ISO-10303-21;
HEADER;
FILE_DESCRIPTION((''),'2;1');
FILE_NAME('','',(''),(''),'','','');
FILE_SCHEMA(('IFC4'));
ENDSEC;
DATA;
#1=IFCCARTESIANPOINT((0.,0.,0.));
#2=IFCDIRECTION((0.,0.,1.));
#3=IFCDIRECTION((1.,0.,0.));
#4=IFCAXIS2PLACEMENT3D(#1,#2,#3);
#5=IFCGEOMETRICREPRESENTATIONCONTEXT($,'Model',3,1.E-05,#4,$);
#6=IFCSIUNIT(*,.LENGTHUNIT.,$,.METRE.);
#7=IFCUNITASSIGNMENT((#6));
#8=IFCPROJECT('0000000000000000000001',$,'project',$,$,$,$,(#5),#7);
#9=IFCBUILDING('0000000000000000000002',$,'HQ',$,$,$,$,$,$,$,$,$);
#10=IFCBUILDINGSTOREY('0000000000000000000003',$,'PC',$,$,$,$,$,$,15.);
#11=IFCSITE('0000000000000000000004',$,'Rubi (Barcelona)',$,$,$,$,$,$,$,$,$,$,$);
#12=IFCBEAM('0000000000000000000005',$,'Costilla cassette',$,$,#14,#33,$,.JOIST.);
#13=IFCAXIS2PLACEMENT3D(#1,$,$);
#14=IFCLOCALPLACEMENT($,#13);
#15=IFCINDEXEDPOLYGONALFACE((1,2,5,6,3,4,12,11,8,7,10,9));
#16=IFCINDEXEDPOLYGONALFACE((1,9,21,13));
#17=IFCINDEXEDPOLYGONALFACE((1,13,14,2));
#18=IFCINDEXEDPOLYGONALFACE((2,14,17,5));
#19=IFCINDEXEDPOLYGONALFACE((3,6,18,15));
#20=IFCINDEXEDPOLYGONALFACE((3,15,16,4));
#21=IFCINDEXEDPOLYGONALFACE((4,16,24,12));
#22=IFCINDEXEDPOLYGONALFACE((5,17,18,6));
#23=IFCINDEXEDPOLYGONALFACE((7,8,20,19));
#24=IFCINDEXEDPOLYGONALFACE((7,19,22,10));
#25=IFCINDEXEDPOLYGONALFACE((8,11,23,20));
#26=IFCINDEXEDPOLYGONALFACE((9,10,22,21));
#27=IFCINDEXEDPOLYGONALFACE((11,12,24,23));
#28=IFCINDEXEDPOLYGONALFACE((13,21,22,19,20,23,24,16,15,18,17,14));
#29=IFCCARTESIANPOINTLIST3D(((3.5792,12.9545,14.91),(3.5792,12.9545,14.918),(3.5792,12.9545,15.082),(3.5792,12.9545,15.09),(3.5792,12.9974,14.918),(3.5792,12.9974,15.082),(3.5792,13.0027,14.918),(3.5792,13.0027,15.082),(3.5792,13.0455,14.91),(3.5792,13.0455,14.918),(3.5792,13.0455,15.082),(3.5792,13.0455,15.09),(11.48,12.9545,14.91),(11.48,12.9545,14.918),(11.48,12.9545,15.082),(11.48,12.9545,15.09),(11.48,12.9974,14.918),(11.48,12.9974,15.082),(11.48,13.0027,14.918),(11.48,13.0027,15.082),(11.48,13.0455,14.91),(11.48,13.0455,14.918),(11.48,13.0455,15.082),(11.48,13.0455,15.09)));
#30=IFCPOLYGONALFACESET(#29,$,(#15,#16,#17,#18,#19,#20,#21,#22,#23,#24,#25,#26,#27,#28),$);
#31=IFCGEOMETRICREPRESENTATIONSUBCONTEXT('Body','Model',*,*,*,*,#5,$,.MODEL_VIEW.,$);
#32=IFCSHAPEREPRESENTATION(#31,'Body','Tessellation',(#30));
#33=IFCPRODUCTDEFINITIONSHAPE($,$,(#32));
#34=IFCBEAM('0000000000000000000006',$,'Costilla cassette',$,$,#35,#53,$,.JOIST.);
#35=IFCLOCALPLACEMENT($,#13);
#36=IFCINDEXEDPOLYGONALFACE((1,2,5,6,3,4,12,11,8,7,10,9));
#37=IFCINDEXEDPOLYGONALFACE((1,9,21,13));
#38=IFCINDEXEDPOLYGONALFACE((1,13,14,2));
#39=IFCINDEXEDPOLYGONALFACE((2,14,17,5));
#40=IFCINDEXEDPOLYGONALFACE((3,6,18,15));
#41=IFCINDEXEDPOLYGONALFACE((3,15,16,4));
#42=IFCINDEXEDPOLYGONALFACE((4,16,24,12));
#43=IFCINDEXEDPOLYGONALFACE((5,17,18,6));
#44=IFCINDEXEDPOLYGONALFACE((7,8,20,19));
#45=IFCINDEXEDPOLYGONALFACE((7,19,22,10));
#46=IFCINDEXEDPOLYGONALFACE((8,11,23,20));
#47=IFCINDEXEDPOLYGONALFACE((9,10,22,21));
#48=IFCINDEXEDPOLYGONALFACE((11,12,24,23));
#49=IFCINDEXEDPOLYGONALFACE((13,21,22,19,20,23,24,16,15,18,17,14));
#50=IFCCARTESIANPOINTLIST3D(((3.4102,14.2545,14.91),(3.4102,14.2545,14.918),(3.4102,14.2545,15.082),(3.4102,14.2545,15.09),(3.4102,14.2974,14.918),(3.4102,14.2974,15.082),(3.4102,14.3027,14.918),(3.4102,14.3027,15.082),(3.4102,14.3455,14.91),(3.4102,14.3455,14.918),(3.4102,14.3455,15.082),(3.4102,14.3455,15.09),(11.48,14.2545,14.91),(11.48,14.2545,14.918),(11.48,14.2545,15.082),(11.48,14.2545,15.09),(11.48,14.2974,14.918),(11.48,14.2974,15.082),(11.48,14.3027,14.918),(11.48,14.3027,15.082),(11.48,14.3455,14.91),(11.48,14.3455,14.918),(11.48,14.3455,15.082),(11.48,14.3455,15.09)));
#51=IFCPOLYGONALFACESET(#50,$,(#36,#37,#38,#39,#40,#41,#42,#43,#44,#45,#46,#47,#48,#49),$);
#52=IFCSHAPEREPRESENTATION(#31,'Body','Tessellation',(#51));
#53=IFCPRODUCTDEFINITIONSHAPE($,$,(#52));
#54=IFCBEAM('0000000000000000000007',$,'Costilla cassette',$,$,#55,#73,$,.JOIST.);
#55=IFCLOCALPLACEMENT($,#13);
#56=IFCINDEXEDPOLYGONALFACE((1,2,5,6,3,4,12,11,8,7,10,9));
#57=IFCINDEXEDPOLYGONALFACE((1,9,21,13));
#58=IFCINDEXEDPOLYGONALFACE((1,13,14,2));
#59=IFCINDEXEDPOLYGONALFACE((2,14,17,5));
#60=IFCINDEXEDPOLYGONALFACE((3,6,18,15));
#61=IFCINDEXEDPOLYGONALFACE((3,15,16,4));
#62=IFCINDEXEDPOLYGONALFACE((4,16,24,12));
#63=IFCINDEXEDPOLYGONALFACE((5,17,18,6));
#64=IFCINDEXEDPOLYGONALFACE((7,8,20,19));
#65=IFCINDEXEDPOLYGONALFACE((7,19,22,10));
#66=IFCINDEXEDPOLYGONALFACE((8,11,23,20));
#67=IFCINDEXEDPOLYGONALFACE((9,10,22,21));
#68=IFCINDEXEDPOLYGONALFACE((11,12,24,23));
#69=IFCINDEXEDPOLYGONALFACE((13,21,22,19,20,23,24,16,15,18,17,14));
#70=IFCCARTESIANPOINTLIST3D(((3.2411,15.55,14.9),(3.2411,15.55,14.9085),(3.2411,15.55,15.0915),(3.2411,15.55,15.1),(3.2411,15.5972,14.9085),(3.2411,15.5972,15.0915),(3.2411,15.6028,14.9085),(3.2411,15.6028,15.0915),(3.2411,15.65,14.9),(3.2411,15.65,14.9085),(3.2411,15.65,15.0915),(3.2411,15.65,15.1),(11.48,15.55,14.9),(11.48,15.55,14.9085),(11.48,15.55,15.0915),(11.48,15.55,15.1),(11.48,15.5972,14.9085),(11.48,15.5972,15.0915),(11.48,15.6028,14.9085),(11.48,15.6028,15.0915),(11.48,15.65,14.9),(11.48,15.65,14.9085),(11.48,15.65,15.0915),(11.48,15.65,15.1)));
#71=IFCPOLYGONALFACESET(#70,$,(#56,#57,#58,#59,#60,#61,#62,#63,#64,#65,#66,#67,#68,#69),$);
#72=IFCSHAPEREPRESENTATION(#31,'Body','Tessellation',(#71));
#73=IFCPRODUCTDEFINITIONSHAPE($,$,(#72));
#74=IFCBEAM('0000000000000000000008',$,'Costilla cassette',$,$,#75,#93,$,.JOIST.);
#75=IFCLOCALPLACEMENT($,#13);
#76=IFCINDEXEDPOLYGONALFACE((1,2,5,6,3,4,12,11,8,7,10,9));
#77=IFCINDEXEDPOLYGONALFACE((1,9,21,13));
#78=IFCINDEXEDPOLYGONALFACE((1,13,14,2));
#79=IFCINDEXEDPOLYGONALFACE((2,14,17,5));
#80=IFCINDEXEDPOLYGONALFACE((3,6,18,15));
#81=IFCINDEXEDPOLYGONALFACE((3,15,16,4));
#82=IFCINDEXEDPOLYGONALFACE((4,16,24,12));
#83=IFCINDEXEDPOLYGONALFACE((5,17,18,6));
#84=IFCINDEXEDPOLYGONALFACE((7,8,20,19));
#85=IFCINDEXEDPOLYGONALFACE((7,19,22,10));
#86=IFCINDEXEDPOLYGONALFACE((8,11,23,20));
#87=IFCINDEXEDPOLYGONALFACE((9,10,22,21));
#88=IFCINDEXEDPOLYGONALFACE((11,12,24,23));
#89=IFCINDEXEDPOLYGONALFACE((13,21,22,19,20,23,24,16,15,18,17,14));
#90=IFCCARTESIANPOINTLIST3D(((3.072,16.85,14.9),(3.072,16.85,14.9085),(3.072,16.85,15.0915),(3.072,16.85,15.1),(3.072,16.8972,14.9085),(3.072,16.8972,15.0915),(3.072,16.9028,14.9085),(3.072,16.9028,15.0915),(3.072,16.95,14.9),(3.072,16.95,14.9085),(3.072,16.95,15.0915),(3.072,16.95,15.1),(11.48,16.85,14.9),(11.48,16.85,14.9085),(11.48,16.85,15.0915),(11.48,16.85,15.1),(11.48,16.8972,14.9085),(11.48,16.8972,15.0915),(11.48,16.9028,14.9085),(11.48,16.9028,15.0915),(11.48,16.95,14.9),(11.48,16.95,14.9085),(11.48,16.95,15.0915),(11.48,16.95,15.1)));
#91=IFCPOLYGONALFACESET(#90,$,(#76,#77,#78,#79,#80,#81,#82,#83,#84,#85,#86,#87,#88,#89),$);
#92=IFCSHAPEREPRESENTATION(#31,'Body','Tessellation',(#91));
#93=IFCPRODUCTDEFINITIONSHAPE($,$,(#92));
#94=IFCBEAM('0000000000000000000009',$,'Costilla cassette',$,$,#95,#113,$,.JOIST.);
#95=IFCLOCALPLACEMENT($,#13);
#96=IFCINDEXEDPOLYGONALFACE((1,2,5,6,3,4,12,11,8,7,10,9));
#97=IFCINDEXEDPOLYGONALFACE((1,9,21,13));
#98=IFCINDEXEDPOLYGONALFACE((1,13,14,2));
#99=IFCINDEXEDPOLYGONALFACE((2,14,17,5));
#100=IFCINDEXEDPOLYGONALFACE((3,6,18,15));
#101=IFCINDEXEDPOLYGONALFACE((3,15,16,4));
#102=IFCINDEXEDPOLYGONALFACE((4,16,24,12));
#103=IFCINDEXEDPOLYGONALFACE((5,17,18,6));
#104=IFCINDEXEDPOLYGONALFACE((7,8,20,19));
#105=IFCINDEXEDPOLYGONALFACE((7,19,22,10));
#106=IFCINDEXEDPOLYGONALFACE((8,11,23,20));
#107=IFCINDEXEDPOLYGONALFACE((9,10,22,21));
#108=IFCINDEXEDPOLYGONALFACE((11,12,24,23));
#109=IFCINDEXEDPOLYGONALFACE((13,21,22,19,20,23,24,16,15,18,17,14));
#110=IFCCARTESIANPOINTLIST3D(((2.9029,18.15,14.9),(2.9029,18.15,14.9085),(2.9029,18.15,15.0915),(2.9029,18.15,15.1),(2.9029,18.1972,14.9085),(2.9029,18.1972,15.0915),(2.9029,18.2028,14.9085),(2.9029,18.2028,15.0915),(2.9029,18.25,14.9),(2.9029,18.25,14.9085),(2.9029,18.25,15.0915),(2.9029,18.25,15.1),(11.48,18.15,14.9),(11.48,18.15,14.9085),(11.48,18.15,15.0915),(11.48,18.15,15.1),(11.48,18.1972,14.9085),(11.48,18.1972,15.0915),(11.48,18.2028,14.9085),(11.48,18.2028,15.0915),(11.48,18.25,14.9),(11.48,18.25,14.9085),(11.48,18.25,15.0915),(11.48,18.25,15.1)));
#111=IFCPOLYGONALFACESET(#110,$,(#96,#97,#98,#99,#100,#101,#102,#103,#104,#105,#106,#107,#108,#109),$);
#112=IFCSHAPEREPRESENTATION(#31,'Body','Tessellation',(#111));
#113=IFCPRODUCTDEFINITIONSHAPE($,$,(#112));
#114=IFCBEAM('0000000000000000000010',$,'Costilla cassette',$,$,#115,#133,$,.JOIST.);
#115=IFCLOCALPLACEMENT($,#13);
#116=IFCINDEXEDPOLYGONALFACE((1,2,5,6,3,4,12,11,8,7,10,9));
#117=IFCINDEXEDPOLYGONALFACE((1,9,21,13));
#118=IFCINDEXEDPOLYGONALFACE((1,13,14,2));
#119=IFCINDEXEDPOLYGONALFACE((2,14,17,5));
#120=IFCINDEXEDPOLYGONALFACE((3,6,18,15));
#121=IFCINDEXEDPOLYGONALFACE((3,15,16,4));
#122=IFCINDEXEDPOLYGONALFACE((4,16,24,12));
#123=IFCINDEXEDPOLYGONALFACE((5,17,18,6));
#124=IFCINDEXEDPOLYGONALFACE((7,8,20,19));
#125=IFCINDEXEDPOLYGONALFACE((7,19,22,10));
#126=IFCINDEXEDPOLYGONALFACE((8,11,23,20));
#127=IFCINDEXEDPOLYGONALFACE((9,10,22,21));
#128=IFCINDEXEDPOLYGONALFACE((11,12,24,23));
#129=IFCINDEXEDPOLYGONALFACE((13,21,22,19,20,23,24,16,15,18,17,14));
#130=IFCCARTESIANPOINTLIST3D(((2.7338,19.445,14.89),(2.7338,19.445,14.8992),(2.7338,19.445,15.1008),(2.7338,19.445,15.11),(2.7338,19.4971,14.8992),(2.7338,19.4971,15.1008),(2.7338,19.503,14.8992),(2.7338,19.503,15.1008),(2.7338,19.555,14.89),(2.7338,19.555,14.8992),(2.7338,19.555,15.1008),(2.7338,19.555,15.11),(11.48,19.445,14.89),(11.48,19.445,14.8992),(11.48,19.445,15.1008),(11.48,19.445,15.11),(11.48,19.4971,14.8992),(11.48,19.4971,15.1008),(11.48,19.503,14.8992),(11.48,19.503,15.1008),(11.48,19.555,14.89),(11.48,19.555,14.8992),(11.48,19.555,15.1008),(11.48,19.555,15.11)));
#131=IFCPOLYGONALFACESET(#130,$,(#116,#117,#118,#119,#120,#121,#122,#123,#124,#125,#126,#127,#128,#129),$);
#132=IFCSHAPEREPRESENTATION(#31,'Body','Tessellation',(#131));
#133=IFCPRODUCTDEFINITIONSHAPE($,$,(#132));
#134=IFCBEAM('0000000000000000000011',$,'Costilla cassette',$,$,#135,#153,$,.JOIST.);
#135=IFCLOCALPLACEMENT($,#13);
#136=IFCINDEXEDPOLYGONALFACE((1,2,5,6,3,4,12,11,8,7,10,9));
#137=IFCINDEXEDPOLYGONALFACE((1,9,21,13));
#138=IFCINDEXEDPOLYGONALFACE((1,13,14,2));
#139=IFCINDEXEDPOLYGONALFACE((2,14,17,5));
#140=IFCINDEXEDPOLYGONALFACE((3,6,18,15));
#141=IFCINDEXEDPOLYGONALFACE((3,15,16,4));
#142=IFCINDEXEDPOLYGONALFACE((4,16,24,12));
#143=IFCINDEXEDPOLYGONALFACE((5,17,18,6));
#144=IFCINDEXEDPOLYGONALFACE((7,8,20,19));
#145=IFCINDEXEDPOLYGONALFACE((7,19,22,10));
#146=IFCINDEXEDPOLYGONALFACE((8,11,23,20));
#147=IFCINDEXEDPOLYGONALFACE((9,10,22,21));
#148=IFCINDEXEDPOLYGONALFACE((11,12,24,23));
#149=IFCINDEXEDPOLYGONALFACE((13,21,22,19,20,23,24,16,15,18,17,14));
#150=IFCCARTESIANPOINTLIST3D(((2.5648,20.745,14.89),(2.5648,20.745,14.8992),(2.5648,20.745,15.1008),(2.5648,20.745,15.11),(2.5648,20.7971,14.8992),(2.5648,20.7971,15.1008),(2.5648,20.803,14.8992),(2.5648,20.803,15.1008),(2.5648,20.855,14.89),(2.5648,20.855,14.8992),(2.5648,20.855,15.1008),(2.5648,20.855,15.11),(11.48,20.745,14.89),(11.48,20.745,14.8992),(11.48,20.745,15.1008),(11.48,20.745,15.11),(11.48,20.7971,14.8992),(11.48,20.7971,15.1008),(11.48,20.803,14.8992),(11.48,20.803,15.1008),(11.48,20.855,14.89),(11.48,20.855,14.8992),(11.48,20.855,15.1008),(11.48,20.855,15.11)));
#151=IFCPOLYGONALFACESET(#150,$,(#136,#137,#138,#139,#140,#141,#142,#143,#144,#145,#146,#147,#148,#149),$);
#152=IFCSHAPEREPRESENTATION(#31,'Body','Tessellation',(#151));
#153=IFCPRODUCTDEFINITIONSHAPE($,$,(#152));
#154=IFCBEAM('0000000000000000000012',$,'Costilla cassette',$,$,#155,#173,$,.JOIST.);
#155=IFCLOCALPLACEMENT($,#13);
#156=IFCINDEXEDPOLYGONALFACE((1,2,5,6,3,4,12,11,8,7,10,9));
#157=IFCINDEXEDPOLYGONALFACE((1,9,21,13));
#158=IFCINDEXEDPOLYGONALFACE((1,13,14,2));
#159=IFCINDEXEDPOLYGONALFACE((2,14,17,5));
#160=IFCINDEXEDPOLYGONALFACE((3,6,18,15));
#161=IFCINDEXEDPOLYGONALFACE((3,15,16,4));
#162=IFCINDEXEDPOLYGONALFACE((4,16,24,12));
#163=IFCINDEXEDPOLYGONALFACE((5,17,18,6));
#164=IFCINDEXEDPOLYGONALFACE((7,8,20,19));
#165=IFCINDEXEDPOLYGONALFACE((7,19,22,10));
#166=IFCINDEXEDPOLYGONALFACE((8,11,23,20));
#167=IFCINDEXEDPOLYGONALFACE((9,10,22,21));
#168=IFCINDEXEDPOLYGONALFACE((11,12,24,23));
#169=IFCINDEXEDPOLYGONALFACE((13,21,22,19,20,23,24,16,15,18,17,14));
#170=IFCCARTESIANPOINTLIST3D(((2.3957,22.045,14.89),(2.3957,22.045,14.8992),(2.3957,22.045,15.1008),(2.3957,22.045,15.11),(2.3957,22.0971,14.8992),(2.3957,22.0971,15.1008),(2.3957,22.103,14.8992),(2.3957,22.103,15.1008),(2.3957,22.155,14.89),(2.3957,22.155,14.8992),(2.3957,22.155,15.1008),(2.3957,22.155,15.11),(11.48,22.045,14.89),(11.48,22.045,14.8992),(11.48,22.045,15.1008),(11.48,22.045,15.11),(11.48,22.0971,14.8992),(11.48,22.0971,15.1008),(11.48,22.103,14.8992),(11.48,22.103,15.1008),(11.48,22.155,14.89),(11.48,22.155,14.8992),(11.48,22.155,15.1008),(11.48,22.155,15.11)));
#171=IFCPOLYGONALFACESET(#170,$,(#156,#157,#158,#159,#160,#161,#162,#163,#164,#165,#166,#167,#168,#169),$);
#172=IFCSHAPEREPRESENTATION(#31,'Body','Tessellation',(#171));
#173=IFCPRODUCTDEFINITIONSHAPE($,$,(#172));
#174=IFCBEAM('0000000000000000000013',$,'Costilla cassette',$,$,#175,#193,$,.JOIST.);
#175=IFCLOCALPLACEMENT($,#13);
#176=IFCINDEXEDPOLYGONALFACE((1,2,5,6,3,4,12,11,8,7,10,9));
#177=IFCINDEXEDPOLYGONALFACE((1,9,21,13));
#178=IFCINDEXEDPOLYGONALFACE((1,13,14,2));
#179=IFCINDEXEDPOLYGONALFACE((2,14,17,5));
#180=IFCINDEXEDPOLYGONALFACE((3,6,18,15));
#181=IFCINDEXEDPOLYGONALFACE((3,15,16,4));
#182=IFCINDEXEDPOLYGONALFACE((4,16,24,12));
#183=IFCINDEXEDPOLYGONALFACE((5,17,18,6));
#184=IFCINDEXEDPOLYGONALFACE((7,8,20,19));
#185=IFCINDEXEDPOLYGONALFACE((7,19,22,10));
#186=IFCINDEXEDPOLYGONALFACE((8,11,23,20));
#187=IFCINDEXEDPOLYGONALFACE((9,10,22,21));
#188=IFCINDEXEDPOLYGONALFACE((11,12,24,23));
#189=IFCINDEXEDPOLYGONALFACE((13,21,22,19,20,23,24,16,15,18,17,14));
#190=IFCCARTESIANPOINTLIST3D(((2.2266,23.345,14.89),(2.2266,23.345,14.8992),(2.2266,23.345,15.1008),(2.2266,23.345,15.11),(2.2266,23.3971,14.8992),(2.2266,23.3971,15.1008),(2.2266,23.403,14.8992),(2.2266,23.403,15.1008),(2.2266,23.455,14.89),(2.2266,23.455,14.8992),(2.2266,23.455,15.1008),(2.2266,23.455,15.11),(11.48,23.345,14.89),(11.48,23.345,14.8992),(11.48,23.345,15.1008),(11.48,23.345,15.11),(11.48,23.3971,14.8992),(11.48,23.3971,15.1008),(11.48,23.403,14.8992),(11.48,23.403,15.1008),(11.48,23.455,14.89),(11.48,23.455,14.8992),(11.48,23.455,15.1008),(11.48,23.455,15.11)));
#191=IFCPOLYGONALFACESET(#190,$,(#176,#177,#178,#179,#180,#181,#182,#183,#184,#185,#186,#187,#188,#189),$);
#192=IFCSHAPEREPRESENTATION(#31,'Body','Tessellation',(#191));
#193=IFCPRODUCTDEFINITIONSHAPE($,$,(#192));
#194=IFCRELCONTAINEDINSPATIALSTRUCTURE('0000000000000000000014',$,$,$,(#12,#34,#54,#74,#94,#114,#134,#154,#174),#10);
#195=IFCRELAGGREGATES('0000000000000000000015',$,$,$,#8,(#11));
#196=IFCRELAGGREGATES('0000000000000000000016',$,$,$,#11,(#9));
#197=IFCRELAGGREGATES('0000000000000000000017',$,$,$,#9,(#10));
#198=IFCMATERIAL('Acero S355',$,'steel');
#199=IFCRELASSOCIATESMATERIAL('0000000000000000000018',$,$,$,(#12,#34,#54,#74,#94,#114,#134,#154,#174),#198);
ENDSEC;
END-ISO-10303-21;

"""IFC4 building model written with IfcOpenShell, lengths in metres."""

from ifc_helpers import new_model, si_unit, frame, origin_with_axes, place, context, subcontext, project, spatial, i_section, extrude, material, element, save


model = new_model("IFC4")

# Units and contexts
model_context = context("Model", 3, precision=1e-05, world=origin_with_axes())
body_context = subcontext(model_context, "Body", "Model", "MODEL_VIEW")
ifc_project = project(units=[si_unit("LENGTHUNIT", "METRE")], contexts=[model_context])

# Site, building, storey
site = spatial("IfcSite", under=ifc_project, Name="Rubi (Barcelona)")
building = spatial("IfcBuilding", under=site, Name="HQ")
storey = spatial("IfcBuildingStorey", under=building, Name="PC", Elevation=15.0)

# Beams
ifc_material_1 = material(Name="Acero S355", Category="steel")
beam_1_placement = place(None, origin_with_axes())
element("IfcBeam", 1, at=beam_1_placement, inside=storey, material=ifc_material_1, Name="Costilla cassette", PredefinedType="JOIST", context=body_context, shape_type="SweptSolid", body=[
    extrude(i_section(OverallWidth=0.091, OverallDepth=0.18, WebThickness=0.0053, FlangeThickness=0.008), frame((3.5792, 13.0, 15.0), z_axis=(1.0, 0.0, 0.0), x_axis=(0.0, 1.0, 0.0)), (0.0, 0.0, 1.0), 7.9008),
])
beam_2_placement = place(None, origin_with_axes())
element("IfcBeam", 2, at=beam_2_placement, inside=storey, material=ifc_material_1, Name="Costilla cassette", PredefinedType="JOIST", context=body_context, shape_type="SweptSolid", body=[
    extrude(i_section(OverallWidth=0.091, OverallDepth=0.18, WebThickness=0.0053, FlangeThickness=0.008), frame((3.4102, 14.3, 15.0), z_axis=(1.0, 0.0, 0.0), x_axis=(0.0, 1.0, 0.0)), (0.0, 0.0, 1.0), 8.0698),
])
beam_3_placement = place(None, origin_with_axes())
element("IfcBeam", 3, at=beam_3_placement, inside=storey, material=ifc_material_1, Name="Costilla cassette", PredefinedType="JOIST", context=body_context, shape_type="SweptSolid", body=[
    extrude(i_section(OverallWidth=0.1, OverallDepth=0.2, WebThickness=0.0056, FlangeThickness=0.0085), frame((3.2411, 15.6, 15.0), z_axis=(1.0, 0.0, 0.0), x_axis=(0.0, 1.0, 0.0)), (0.0, 0.0, 1.0), 8.2389),
])
beam_4_placement = place(None, origin_with_axes())
element("IfcBeam", 4, at=beam_4_placement, inside=storey, material=ifc_material_1, Name="Costilla cassette", PredefinedType="JOIST", context=body_context, shape_type="SweptSolid", body=[
    extrude(i_section(OverallWidth=0.1, OverallDepth=0.2, WebThickness=0.0056, FlangeThickness=0.0085), frame((3.072, 16.9, 15.0), z_axis=(1.0, 0.0, 0.0), x_axis=(0.0, 1.0, 0.0)), (0.0, 0.0, 1.0), 8.408),
])
beam_5_placement = place(None, origin_with_axes())
element("IfcBeam", 5, at=beam_5_placement, inside=storey, material=ifc_material_1, Name="Costilla cassette", PredefinedType="JOIST", context=body_context, shape_type="SweptSolid", body=[
    extrude(i_section(OverallWidth=0.1, OverallDepth=0.2, WebThickness=0.0056, FlangeThickness=0.0085), frame((2.9029, 18.2, 15.0), z_axis=(1.0, 0.0, 0.0), x_axis=(0.0, 1.0, 0.0)), (0.0, 0.0, 1.0), 8.5771),
])
beam_6_placement = place(None, origin_with_axes())
element("IfcBeam", 6, at=beam_6_placement, inside=storey, material=ifc_material_1, Name="Costilla cassette", PredefinedType="JOIST", context=body_context, shape_type="SweptSolid", body=[
    extrude(i_section(OverallWidth=0.11, OverallDepth=0.22, WebThickness=0.0059, FlangeThickness=0.0092), frame((2.7338, 19.5, 15.0), z_axis=(1.0, 0.0, 0.0), x_axis=(0.0, 1.0, 0.0)), (0.0, 0.0, 1.0), 8.7462),
])
beam_7_placement = place(None, origin_with_axes())
element("IfcBeam", 7, at=beam_7_placement, inside=storey, material=ifc_material_1, Name="Costilla cassette", PredefinedType="JOIST", context=body_context, shape_type="SweptSolid", body=[
    extrude(i_section(OverallWidth=0.11, OverallDepth=0.22, WebThickness=0.0059, FlangeThickness=0.0092), frame((2.5648, 20.8, 15.0), z_axis=(1.0, 0.0, 0.0), x_axis=(0.0, 1.0, 0.0)), (0.0, 0.0, 1.0), 8.9152),
])
beam_8_placement = place(None, origin_with_axes())
element("IfcBeam", 8, at=beam_8_placement, inside=storey, material=ifc_material_1, Name="Costilla cassette", PredefinedType="JOIST", context=body_context, shape_type="SweptSolid", body=[
    extrude(i_section(OverallWidth=0.11, OverallDepth=0.22, WebThickness=0.0059, FlangeThickness=0.0092), frame((2.3957, 22.1, 15.0), z_axis=(1.0, 0.0, 0.0), x_axis=(0.0, 1.0, 0.0)), (0.0, 0.0, 1.0), 9.0843),
])
beam_9_placement = place(None, origin_with_axes())
element("IfcBeam", 9, at=beam_9_placement, inside=storey, material=ifc_material_1, Name="Costilla cassette", PredefinedType="JOIST", context=body_context, shape_type="SweptSolid", body=[
    extrude(i_section(OverallWidth=0.11, OverallDepth=0.22, WebThickness=0.0059, FlangeThickness=0.0092), frame((2.2266, 23.4, 15.0), z_axis=(1.0, 0.0, 0.0), x_axis=(0.0, 1.0, 0.0)), (0.0, 0.0, 1.0), 9.2534),
])

save(model, "model.ifc")
